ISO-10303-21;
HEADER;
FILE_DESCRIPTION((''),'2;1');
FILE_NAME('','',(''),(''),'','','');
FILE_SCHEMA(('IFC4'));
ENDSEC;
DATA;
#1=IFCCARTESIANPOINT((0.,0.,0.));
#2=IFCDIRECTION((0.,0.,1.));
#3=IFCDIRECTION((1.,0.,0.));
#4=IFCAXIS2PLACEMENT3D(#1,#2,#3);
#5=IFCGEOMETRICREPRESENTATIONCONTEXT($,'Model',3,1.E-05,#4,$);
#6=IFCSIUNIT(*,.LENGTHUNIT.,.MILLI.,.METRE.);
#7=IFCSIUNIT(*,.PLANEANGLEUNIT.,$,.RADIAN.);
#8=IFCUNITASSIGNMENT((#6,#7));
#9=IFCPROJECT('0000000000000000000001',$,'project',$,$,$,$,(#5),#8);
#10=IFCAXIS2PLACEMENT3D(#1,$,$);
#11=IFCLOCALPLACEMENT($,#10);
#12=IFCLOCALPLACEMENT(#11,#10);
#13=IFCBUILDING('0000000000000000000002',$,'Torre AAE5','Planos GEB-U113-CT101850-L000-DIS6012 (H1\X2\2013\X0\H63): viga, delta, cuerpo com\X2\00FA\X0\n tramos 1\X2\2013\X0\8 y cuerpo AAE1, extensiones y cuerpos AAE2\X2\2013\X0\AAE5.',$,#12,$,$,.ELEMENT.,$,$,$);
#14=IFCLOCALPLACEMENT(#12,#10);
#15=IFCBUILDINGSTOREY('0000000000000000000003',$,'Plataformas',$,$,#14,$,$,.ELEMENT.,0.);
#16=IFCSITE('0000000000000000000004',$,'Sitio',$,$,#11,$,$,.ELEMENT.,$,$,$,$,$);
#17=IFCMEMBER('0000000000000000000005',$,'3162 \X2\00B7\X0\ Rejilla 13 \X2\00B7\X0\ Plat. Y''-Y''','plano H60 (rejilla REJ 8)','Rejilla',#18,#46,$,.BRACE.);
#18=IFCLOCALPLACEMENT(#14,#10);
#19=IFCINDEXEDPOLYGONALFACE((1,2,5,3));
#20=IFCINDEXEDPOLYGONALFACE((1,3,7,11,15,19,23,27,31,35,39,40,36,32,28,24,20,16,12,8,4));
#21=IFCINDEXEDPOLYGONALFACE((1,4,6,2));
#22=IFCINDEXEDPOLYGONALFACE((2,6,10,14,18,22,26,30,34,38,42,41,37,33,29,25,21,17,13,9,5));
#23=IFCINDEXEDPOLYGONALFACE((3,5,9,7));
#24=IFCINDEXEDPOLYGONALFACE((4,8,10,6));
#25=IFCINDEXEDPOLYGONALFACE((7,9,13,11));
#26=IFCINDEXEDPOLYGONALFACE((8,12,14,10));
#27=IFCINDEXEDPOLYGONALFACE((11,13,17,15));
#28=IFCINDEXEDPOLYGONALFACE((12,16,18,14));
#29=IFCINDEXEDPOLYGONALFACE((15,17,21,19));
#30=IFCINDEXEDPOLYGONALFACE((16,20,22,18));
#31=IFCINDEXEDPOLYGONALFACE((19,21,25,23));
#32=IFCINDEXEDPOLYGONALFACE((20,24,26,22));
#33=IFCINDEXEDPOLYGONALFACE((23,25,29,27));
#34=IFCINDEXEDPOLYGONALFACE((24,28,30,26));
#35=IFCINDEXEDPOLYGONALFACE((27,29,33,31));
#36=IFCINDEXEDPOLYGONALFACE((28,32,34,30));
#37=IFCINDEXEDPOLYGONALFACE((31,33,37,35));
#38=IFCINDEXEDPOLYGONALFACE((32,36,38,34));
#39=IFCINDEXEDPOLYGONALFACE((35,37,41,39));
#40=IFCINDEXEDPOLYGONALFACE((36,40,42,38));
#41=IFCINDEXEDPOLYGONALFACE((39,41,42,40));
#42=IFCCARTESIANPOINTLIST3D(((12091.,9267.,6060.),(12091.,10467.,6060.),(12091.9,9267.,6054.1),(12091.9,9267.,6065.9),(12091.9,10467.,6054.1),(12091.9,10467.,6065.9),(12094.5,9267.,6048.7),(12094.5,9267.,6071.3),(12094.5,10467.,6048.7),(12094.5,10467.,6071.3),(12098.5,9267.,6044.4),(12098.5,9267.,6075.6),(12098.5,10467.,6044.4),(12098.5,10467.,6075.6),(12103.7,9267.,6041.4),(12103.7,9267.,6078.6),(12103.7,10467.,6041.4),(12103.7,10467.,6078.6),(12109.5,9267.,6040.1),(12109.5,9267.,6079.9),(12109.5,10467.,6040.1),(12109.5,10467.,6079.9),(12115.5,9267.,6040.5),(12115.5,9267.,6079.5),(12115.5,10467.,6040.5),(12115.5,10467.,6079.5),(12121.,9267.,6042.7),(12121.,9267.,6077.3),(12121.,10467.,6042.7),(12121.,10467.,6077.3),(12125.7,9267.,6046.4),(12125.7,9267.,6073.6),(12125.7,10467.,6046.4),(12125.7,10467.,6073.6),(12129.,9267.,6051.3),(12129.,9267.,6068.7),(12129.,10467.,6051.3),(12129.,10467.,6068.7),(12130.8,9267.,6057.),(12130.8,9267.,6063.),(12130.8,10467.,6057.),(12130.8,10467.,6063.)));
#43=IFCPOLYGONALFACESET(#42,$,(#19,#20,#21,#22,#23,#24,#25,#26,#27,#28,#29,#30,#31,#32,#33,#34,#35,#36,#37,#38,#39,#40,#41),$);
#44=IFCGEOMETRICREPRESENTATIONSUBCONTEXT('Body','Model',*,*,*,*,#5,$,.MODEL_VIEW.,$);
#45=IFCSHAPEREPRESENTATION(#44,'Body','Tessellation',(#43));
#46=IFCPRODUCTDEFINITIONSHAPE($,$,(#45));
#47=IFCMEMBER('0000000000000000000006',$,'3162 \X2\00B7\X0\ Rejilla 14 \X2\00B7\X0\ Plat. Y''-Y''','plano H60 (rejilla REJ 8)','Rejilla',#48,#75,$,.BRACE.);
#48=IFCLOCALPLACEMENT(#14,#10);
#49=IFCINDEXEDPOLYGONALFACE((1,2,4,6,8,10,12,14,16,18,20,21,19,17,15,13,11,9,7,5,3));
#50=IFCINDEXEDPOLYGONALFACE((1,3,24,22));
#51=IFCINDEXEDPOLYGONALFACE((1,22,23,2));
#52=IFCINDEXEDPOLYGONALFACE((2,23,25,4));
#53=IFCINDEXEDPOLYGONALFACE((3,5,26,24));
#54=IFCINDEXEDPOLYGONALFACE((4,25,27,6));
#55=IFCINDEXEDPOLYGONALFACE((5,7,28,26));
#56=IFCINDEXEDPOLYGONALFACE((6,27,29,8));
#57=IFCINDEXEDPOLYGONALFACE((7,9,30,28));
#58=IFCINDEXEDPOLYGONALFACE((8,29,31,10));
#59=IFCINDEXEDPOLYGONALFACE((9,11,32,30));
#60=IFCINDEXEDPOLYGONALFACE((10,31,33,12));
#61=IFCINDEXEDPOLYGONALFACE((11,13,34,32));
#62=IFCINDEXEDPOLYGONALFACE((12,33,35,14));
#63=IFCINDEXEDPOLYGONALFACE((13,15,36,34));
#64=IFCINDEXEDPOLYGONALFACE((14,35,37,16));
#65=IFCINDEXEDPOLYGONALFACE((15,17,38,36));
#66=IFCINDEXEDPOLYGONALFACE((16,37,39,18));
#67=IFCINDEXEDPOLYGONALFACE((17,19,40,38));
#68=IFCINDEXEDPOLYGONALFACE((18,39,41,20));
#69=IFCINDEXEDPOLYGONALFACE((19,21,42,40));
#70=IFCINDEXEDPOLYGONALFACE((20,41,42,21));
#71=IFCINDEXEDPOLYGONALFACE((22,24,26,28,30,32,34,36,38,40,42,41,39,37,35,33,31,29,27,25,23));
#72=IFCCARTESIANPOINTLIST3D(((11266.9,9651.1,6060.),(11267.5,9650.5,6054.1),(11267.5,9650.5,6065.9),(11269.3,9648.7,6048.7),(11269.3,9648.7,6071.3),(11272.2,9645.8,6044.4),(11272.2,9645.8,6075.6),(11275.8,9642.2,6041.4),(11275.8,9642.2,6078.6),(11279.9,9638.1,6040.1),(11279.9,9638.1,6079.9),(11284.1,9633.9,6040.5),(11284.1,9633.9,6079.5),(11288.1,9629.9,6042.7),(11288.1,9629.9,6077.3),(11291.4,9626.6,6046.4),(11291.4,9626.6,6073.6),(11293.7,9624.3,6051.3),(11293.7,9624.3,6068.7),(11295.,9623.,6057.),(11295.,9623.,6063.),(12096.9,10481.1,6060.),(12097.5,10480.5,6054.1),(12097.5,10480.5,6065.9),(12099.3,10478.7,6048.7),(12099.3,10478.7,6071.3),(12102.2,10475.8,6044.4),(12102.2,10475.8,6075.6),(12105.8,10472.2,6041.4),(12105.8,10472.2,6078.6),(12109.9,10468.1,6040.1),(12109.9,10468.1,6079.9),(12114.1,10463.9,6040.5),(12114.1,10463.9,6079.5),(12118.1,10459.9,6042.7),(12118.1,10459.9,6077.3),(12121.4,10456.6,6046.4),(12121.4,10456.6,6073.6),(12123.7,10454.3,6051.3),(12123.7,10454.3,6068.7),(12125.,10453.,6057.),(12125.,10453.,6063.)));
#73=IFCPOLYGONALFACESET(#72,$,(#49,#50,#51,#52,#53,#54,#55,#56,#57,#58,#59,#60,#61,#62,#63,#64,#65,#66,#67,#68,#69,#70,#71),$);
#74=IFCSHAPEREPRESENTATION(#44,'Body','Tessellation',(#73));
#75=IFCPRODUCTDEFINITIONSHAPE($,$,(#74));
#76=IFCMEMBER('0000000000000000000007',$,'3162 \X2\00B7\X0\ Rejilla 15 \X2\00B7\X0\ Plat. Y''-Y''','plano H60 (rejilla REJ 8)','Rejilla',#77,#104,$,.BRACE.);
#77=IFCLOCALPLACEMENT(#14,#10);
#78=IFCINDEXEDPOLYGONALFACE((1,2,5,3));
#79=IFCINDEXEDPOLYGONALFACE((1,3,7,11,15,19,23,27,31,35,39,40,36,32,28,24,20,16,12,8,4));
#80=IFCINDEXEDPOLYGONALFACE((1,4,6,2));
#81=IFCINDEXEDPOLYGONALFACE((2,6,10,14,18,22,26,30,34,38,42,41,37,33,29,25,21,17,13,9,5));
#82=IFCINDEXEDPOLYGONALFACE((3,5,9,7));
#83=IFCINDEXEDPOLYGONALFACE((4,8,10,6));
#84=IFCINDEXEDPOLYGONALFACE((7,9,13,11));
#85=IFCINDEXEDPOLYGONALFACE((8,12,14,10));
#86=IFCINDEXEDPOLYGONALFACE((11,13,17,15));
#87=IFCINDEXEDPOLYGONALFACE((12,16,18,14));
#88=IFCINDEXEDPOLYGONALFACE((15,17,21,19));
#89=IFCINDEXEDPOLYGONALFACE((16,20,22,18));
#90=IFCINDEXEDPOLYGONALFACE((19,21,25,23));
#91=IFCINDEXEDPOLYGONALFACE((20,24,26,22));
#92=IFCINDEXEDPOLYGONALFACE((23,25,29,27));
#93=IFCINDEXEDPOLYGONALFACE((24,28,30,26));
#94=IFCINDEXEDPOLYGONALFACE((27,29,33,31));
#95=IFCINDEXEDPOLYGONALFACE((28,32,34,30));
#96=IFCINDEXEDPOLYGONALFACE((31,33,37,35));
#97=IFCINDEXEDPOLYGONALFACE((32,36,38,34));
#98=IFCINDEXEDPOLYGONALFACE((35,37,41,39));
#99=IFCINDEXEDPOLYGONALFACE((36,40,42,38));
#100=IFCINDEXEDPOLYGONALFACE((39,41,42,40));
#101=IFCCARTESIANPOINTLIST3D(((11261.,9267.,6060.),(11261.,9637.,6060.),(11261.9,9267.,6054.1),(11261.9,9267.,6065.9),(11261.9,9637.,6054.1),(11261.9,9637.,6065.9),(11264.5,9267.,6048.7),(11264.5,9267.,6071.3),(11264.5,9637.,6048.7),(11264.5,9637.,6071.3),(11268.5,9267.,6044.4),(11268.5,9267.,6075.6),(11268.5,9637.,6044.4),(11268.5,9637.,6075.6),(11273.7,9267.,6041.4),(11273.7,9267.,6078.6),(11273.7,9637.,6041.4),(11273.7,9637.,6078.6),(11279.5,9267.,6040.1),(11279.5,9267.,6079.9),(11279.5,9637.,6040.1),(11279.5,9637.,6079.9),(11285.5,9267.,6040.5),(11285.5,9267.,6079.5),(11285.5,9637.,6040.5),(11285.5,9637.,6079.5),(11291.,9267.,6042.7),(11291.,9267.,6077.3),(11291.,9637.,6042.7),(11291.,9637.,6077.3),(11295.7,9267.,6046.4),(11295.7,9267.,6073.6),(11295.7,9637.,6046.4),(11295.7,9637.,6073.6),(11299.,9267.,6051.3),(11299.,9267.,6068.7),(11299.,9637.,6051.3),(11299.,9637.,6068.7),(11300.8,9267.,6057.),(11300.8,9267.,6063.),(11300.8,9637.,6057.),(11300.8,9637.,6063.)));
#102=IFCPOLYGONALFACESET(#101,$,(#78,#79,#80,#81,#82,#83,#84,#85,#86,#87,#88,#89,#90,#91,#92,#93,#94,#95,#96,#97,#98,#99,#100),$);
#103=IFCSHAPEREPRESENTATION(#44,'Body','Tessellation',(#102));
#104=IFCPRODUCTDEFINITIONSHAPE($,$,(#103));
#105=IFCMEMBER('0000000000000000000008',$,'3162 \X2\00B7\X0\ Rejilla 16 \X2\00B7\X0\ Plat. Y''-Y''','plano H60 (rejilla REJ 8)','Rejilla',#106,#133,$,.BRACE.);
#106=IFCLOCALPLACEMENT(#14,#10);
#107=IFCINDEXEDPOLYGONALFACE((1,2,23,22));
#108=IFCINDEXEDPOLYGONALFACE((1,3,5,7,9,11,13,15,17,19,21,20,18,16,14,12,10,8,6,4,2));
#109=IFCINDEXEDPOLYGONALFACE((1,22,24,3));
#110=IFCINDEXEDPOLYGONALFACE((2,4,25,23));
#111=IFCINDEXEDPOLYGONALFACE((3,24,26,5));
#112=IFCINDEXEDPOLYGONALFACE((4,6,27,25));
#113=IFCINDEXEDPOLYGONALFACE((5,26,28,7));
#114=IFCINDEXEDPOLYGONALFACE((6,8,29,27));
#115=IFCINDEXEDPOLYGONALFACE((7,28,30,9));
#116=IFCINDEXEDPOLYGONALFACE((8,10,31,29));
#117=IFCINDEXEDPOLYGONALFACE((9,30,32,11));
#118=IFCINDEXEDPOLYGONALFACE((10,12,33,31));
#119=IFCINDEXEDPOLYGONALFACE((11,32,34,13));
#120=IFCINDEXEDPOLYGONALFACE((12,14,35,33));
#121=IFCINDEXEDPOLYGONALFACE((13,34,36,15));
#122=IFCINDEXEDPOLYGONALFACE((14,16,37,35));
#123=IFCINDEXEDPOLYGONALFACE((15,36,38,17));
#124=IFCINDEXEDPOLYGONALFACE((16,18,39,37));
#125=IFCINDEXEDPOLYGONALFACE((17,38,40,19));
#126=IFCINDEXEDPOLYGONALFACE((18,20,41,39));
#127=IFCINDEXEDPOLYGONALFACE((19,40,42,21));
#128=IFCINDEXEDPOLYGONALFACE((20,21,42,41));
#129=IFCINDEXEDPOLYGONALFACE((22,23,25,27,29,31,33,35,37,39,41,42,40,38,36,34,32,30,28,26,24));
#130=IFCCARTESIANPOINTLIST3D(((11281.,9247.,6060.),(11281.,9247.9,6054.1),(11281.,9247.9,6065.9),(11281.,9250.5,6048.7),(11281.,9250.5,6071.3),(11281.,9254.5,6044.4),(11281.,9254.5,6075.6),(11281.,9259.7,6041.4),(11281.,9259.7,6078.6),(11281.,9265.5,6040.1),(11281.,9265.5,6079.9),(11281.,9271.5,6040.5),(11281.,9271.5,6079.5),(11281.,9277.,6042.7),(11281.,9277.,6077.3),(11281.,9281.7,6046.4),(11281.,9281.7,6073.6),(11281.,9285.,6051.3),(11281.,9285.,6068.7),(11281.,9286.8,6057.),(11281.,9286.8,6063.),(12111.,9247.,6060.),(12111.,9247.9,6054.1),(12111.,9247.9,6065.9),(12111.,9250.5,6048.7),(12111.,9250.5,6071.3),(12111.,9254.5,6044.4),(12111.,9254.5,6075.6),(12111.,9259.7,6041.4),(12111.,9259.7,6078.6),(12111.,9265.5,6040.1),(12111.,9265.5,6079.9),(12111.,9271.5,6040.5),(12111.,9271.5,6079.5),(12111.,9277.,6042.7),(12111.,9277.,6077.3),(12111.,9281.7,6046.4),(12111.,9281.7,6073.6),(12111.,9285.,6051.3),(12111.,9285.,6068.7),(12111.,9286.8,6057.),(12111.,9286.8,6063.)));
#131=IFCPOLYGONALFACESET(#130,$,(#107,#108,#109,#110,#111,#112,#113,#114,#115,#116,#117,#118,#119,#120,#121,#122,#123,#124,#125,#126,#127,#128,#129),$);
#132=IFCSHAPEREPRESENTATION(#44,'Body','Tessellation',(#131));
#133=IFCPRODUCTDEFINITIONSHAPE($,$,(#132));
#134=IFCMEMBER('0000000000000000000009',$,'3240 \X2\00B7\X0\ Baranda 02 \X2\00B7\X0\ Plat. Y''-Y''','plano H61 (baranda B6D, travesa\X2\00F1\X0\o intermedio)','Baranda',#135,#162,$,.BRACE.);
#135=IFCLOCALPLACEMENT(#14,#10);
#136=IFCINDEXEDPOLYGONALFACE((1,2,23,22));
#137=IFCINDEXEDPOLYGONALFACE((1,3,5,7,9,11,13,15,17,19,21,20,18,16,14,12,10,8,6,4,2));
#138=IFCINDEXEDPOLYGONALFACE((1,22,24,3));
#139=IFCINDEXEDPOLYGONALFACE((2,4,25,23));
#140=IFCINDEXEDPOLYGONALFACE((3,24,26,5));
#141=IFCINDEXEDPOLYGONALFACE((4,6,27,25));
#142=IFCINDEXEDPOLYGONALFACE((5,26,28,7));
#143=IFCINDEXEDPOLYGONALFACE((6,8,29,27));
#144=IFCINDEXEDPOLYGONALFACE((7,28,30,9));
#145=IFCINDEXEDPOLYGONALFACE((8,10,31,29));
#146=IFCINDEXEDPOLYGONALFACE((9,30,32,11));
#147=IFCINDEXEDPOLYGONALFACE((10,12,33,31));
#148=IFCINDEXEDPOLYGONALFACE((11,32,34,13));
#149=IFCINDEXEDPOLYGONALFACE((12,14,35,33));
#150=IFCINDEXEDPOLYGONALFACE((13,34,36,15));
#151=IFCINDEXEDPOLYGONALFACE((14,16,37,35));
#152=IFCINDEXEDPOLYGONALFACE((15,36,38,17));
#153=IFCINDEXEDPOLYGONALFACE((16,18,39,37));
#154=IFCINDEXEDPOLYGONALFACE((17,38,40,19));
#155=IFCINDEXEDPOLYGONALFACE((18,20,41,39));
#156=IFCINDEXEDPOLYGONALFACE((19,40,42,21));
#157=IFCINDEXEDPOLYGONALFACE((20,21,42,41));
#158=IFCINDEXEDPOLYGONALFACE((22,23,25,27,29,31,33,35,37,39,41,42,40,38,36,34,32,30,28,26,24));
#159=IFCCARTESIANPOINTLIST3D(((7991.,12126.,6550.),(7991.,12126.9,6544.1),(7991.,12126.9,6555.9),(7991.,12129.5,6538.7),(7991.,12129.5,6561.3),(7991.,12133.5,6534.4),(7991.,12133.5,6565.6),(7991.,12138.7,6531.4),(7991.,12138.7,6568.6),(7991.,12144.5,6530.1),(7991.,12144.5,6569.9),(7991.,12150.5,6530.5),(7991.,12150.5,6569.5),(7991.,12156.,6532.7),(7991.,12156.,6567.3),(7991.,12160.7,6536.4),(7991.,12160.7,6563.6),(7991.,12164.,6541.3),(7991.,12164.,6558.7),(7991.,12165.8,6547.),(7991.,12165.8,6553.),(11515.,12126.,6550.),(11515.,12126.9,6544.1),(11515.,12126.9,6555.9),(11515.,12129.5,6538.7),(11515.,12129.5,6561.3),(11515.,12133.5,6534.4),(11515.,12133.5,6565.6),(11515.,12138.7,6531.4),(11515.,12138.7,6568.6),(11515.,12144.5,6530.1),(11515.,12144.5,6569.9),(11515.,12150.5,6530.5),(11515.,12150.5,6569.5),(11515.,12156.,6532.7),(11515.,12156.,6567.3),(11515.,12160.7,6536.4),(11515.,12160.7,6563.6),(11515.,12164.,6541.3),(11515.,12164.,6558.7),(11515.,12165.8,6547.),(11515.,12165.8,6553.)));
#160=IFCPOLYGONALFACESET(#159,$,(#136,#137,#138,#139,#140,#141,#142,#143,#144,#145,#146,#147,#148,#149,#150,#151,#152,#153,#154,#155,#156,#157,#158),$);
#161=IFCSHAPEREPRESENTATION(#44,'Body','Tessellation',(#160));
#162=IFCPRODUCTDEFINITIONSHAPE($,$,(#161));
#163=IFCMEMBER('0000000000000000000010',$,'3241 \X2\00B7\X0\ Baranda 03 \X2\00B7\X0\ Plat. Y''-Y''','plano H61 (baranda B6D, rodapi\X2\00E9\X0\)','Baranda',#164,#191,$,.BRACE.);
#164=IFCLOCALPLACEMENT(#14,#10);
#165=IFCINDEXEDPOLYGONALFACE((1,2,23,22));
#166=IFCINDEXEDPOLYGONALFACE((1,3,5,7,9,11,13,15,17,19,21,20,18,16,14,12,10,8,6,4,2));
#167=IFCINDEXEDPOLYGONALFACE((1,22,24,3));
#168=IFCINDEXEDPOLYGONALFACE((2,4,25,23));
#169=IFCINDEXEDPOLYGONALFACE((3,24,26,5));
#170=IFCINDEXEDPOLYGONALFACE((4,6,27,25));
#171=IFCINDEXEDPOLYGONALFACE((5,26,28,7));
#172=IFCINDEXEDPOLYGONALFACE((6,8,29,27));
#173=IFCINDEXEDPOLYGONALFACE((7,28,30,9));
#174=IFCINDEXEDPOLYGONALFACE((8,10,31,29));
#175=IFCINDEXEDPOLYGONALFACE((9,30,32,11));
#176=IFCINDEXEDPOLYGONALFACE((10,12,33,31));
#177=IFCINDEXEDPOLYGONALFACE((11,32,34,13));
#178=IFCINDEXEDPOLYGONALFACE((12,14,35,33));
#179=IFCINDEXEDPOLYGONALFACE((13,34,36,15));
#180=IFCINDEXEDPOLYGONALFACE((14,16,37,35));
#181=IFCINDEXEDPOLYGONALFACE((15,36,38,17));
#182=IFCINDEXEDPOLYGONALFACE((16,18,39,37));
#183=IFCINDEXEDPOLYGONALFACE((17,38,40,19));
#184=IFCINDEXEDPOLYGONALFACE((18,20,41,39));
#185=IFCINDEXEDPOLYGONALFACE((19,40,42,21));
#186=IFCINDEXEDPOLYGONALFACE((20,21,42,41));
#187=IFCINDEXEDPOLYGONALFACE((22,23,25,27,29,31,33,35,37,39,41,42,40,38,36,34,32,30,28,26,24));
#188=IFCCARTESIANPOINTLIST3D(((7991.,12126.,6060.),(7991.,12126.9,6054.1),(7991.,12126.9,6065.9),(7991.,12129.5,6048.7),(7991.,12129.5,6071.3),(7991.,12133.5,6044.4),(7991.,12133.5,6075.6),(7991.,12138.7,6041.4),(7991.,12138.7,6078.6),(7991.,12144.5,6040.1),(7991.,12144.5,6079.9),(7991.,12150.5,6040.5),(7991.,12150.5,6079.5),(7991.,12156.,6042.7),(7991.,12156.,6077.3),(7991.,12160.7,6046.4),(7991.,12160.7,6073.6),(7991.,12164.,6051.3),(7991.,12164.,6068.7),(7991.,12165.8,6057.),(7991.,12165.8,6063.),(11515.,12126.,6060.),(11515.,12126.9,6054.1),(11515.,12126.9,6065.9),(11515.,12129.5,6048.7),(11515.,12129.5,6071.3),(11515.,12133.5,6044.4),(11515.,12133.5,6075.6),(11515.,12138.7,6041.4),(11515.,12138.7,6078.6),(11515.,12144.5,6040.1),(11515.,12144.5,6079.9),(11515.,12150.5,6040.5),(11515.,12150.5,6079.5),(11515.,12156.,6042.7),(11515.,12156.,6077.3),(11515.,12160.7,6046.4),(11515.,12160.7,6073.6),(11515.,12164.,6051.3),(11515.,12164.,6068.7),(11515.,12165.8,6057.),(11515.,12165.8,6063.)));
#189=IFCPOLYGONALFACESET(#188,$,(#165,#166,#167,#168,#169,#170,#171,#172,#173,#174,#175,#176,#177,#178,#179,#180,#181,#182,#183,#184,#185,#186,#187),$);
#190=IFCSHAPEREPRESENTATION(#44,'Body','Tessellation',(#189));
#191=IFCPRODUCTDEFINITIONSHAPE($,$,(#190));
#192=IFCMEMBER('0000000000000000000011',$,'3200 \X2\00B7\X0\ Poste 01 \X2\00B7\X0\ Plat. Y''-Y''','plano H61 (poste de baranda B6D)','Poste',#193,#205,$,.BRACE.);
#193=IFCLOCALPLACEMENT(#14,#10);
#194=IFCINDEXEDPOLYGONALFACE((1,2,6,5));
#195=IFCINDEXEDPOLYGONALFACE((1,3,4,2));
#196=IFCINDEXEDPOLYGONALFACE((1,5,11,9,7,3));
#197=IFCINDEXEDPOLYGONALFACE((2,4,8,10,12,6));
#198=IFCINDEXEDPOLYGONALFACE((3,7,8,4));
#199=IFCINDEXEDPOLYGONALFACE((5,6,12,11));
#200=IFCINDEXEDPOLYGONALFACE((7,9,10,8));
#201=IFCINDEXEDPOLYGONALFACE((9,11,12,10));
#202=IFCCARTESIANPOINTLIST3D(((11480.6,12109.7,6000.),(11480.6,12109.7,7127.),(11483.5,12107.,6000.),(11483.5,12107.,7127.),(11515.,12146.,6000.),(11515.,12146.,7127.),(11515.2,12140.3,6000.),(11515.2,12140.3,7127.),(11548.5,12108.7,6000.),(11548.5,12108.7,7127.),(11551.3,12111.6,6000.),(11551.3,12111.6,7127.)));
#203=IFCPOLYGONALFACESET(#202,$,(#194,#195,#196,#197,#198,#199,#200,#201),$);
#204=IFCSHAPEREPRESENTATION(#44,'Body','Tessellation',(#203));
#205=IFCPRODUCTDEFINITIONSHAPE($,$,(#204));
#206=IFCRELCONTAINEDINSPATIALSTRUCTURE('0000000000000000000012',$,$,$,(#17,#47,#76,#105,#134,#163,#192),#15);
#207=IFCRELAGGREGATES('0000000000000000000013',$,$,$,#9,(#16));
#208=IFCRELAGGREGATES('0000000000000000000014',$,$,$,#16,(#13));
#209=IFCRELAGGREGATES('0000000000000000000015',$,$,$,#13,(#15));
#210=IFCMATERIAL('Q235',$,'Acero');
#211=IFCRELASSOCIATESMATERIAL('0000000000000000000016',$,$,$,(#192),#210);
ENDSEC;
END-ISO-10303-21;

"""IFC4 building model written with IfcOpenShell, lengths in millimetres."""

from ifc_helpers import new_model, si_unit, frame, frame_2d, origin, origin_with_axes, place, context, subcontext, project, spatial, circle, l_section, extrude, material, element, save


model = new_model("IFC4")

# Units and contexts
model_context = context("Model", 3, precision=1e-05, world=origin_with_axes())
body_context = subcontext(model_context, "Body", "Model", "MODEL_VIEW")
ifc_project = project(units=[si_unit("LENGTHUNIT", "METRE", prefix="MILLI"), si_unit("PLANEANGLEUNIT", "RADIAN")], contexts=[model_context])

# Site, building, storey
site_placement = place(None, origin())
site = spatial("IfcSite", under=ifc_project, at=site_placement, Name="Sitio", CompositionType="ELEMENT")
building_placement = place(site_placement, origin())
building = spatial("IfcBuilding", under=site, at=building_placement, Name="Torre AAE5", Description="Planos GEB-U113-CT101850-L000-DIS6012 (H1–H63): viga, delta, cuerpo común tramos 1–8 y cuerpo AAE1, extensiones y cuerpos AAE2–AAE5.", CompositionType="ELEMENT")
storey_placement = place(building_placement, origin())
storey = spatial("IfcBuildingStorey", under=building, at=storey_placement, Name="Plataformas", CompositionType="ELEMENT", Elevation=0.0)

# Members
member_1_placement = place(storey_placement, frame((12111.0, 9267.0, 6060.0), z_axis=(0.0, 1.0, 0.0), x_axis=(-1.0, 0.0, 0.0)))
element("IfcMember", 1, at=member_1_placement, inside=storey, Name="3162 · Rejilla 13 · Plat. Y'-Y'", Description="plano H60 (rejilla REJ 8)", ObjectType="Rejilla", PredefinedType="BRACE", context=body_context, shape_type="SweptSolid", body=[
    extrude(circle(Radius=20.0), None, (0.0, 0.0, 1.0), 1200.0),
])
member_2_placement = place(storey_placement, frame((12111.0, 10467.0, 6060.0), z_axis=(-0.707107, -0.707107, 0.0), x_axis=(-0.707107, 0.707107, 0.0)))
element("IfcMember", 2, at=member_2_placement, inside=storey, Name="3162 · Rejilla 14 · Plat. Y'-Y'", Description="plano H60 (rejilla REJ 8)", ObjectType="Rejilla", PredefinedType="BRACE", context=body_context, shape_type="SweptSolid", body=[
    extrude(circle(Radius=20.0), None, (0.0, 0.0, 1.0), 1173.8),
])
member_3_placement = place(storey_placement, frame((11281.0, 9637.0, 6060.0), z_axis=(0.0, -1.0, 0.0), x_axis=(-1.0, 0.0, 0.0)))
element("IfcMember", 3, at=member_3_placement, inside=storey, Name="3162 · Rejilla 15 · Plat. Y'-Y'", Description="plano H60 (rejilla REJ 8)", ObjectType="Rejilla", PredefinedType="BRACE", context=body_context, shape_type="SweptSolid", body=[
    extrude(circle(Radius=20.0), None, (0.0, 0.0, 1.0), 370.0),
])
member_4_placement = place(storey_placement, frame((11281.0, 9267.0, 6060.0), z_axis=(1.0, 0.0, 0.0), x_axis=(0.0, -1.0, 0.0)))
element("IfcMember", 4, at=member_4_placement, inside=storey, Name="3162 · Rejilla 16 · Plat. Y'-Y'", Description="plano H60 (rejilla REJ 8)", ObjectType="Rejilla", PredefinedType="BRACE", context=body_context, shape_type="SweptSolid", body=[
    extrude(circle(Radius=20.0), None, (0.0, 0.0, 1.0), 830.0),
])
for number, where, z_axis, x_axis, name, description in (
    (5, (11515.0, 12146.0, 6550.0), (-1.0, 0.0, 0.0), (0.0, -1.0, 0.0), "3240 · Baranda 02 · Plat. Y'-Y'", "plano H61 (baranda B6D, travesaño intermedio)"),
    (6, (11515.0, 12146.0, 6060.0), (-1.0, 0.0, 0.0), (0.0, -1.0, 0.0), "3241 · Baranda 03 · Plat. Y'-Y'", "plano H61 (baranda B6D, rodapié)"),
):
    element("IfcMember", number, at=place(storey_placement, frame(where, z_axis=z_axis, x_axis=x_axis)), inside=storey, Name=name, Description=description, ObjectType="Baranda", PredefinedType="BRACE", context=body_context, shape_type="SweptSolid", body=[
        extrude(circle(Radius=20.0), None, (0.0, 0.0, 1.0), 3524.0),
    ])
ifc_material = material(Name="Q235", Category="Acero")
member_5_placement = place(storey_placement, frame((11515.0, 12146.0, 6000.0), z_axis=(0.0, 0.0, 1.0), x_axis=(-0.688005, -0.725706, 0.0)))
element("IfcMember", 7, at=member_5_placement, inside=storey, material=ifc_material, Name="3200 · Poste 01 · Plat. Y'-Y'", Description="plano H61 (poste de baranda B6D)", ObjectType="Poste", PredefinedType="BRACE", context=body_context, shape_type="SweptSolid", body=[
    extrude(l_section(Depth=50.0, Width=50.0, Thickness=4.0, at=frame_2d((25.0, 25.0))), None, (0.0, 0.0, 1.0), 1127.0),
])

save(model, "model.ifc")
